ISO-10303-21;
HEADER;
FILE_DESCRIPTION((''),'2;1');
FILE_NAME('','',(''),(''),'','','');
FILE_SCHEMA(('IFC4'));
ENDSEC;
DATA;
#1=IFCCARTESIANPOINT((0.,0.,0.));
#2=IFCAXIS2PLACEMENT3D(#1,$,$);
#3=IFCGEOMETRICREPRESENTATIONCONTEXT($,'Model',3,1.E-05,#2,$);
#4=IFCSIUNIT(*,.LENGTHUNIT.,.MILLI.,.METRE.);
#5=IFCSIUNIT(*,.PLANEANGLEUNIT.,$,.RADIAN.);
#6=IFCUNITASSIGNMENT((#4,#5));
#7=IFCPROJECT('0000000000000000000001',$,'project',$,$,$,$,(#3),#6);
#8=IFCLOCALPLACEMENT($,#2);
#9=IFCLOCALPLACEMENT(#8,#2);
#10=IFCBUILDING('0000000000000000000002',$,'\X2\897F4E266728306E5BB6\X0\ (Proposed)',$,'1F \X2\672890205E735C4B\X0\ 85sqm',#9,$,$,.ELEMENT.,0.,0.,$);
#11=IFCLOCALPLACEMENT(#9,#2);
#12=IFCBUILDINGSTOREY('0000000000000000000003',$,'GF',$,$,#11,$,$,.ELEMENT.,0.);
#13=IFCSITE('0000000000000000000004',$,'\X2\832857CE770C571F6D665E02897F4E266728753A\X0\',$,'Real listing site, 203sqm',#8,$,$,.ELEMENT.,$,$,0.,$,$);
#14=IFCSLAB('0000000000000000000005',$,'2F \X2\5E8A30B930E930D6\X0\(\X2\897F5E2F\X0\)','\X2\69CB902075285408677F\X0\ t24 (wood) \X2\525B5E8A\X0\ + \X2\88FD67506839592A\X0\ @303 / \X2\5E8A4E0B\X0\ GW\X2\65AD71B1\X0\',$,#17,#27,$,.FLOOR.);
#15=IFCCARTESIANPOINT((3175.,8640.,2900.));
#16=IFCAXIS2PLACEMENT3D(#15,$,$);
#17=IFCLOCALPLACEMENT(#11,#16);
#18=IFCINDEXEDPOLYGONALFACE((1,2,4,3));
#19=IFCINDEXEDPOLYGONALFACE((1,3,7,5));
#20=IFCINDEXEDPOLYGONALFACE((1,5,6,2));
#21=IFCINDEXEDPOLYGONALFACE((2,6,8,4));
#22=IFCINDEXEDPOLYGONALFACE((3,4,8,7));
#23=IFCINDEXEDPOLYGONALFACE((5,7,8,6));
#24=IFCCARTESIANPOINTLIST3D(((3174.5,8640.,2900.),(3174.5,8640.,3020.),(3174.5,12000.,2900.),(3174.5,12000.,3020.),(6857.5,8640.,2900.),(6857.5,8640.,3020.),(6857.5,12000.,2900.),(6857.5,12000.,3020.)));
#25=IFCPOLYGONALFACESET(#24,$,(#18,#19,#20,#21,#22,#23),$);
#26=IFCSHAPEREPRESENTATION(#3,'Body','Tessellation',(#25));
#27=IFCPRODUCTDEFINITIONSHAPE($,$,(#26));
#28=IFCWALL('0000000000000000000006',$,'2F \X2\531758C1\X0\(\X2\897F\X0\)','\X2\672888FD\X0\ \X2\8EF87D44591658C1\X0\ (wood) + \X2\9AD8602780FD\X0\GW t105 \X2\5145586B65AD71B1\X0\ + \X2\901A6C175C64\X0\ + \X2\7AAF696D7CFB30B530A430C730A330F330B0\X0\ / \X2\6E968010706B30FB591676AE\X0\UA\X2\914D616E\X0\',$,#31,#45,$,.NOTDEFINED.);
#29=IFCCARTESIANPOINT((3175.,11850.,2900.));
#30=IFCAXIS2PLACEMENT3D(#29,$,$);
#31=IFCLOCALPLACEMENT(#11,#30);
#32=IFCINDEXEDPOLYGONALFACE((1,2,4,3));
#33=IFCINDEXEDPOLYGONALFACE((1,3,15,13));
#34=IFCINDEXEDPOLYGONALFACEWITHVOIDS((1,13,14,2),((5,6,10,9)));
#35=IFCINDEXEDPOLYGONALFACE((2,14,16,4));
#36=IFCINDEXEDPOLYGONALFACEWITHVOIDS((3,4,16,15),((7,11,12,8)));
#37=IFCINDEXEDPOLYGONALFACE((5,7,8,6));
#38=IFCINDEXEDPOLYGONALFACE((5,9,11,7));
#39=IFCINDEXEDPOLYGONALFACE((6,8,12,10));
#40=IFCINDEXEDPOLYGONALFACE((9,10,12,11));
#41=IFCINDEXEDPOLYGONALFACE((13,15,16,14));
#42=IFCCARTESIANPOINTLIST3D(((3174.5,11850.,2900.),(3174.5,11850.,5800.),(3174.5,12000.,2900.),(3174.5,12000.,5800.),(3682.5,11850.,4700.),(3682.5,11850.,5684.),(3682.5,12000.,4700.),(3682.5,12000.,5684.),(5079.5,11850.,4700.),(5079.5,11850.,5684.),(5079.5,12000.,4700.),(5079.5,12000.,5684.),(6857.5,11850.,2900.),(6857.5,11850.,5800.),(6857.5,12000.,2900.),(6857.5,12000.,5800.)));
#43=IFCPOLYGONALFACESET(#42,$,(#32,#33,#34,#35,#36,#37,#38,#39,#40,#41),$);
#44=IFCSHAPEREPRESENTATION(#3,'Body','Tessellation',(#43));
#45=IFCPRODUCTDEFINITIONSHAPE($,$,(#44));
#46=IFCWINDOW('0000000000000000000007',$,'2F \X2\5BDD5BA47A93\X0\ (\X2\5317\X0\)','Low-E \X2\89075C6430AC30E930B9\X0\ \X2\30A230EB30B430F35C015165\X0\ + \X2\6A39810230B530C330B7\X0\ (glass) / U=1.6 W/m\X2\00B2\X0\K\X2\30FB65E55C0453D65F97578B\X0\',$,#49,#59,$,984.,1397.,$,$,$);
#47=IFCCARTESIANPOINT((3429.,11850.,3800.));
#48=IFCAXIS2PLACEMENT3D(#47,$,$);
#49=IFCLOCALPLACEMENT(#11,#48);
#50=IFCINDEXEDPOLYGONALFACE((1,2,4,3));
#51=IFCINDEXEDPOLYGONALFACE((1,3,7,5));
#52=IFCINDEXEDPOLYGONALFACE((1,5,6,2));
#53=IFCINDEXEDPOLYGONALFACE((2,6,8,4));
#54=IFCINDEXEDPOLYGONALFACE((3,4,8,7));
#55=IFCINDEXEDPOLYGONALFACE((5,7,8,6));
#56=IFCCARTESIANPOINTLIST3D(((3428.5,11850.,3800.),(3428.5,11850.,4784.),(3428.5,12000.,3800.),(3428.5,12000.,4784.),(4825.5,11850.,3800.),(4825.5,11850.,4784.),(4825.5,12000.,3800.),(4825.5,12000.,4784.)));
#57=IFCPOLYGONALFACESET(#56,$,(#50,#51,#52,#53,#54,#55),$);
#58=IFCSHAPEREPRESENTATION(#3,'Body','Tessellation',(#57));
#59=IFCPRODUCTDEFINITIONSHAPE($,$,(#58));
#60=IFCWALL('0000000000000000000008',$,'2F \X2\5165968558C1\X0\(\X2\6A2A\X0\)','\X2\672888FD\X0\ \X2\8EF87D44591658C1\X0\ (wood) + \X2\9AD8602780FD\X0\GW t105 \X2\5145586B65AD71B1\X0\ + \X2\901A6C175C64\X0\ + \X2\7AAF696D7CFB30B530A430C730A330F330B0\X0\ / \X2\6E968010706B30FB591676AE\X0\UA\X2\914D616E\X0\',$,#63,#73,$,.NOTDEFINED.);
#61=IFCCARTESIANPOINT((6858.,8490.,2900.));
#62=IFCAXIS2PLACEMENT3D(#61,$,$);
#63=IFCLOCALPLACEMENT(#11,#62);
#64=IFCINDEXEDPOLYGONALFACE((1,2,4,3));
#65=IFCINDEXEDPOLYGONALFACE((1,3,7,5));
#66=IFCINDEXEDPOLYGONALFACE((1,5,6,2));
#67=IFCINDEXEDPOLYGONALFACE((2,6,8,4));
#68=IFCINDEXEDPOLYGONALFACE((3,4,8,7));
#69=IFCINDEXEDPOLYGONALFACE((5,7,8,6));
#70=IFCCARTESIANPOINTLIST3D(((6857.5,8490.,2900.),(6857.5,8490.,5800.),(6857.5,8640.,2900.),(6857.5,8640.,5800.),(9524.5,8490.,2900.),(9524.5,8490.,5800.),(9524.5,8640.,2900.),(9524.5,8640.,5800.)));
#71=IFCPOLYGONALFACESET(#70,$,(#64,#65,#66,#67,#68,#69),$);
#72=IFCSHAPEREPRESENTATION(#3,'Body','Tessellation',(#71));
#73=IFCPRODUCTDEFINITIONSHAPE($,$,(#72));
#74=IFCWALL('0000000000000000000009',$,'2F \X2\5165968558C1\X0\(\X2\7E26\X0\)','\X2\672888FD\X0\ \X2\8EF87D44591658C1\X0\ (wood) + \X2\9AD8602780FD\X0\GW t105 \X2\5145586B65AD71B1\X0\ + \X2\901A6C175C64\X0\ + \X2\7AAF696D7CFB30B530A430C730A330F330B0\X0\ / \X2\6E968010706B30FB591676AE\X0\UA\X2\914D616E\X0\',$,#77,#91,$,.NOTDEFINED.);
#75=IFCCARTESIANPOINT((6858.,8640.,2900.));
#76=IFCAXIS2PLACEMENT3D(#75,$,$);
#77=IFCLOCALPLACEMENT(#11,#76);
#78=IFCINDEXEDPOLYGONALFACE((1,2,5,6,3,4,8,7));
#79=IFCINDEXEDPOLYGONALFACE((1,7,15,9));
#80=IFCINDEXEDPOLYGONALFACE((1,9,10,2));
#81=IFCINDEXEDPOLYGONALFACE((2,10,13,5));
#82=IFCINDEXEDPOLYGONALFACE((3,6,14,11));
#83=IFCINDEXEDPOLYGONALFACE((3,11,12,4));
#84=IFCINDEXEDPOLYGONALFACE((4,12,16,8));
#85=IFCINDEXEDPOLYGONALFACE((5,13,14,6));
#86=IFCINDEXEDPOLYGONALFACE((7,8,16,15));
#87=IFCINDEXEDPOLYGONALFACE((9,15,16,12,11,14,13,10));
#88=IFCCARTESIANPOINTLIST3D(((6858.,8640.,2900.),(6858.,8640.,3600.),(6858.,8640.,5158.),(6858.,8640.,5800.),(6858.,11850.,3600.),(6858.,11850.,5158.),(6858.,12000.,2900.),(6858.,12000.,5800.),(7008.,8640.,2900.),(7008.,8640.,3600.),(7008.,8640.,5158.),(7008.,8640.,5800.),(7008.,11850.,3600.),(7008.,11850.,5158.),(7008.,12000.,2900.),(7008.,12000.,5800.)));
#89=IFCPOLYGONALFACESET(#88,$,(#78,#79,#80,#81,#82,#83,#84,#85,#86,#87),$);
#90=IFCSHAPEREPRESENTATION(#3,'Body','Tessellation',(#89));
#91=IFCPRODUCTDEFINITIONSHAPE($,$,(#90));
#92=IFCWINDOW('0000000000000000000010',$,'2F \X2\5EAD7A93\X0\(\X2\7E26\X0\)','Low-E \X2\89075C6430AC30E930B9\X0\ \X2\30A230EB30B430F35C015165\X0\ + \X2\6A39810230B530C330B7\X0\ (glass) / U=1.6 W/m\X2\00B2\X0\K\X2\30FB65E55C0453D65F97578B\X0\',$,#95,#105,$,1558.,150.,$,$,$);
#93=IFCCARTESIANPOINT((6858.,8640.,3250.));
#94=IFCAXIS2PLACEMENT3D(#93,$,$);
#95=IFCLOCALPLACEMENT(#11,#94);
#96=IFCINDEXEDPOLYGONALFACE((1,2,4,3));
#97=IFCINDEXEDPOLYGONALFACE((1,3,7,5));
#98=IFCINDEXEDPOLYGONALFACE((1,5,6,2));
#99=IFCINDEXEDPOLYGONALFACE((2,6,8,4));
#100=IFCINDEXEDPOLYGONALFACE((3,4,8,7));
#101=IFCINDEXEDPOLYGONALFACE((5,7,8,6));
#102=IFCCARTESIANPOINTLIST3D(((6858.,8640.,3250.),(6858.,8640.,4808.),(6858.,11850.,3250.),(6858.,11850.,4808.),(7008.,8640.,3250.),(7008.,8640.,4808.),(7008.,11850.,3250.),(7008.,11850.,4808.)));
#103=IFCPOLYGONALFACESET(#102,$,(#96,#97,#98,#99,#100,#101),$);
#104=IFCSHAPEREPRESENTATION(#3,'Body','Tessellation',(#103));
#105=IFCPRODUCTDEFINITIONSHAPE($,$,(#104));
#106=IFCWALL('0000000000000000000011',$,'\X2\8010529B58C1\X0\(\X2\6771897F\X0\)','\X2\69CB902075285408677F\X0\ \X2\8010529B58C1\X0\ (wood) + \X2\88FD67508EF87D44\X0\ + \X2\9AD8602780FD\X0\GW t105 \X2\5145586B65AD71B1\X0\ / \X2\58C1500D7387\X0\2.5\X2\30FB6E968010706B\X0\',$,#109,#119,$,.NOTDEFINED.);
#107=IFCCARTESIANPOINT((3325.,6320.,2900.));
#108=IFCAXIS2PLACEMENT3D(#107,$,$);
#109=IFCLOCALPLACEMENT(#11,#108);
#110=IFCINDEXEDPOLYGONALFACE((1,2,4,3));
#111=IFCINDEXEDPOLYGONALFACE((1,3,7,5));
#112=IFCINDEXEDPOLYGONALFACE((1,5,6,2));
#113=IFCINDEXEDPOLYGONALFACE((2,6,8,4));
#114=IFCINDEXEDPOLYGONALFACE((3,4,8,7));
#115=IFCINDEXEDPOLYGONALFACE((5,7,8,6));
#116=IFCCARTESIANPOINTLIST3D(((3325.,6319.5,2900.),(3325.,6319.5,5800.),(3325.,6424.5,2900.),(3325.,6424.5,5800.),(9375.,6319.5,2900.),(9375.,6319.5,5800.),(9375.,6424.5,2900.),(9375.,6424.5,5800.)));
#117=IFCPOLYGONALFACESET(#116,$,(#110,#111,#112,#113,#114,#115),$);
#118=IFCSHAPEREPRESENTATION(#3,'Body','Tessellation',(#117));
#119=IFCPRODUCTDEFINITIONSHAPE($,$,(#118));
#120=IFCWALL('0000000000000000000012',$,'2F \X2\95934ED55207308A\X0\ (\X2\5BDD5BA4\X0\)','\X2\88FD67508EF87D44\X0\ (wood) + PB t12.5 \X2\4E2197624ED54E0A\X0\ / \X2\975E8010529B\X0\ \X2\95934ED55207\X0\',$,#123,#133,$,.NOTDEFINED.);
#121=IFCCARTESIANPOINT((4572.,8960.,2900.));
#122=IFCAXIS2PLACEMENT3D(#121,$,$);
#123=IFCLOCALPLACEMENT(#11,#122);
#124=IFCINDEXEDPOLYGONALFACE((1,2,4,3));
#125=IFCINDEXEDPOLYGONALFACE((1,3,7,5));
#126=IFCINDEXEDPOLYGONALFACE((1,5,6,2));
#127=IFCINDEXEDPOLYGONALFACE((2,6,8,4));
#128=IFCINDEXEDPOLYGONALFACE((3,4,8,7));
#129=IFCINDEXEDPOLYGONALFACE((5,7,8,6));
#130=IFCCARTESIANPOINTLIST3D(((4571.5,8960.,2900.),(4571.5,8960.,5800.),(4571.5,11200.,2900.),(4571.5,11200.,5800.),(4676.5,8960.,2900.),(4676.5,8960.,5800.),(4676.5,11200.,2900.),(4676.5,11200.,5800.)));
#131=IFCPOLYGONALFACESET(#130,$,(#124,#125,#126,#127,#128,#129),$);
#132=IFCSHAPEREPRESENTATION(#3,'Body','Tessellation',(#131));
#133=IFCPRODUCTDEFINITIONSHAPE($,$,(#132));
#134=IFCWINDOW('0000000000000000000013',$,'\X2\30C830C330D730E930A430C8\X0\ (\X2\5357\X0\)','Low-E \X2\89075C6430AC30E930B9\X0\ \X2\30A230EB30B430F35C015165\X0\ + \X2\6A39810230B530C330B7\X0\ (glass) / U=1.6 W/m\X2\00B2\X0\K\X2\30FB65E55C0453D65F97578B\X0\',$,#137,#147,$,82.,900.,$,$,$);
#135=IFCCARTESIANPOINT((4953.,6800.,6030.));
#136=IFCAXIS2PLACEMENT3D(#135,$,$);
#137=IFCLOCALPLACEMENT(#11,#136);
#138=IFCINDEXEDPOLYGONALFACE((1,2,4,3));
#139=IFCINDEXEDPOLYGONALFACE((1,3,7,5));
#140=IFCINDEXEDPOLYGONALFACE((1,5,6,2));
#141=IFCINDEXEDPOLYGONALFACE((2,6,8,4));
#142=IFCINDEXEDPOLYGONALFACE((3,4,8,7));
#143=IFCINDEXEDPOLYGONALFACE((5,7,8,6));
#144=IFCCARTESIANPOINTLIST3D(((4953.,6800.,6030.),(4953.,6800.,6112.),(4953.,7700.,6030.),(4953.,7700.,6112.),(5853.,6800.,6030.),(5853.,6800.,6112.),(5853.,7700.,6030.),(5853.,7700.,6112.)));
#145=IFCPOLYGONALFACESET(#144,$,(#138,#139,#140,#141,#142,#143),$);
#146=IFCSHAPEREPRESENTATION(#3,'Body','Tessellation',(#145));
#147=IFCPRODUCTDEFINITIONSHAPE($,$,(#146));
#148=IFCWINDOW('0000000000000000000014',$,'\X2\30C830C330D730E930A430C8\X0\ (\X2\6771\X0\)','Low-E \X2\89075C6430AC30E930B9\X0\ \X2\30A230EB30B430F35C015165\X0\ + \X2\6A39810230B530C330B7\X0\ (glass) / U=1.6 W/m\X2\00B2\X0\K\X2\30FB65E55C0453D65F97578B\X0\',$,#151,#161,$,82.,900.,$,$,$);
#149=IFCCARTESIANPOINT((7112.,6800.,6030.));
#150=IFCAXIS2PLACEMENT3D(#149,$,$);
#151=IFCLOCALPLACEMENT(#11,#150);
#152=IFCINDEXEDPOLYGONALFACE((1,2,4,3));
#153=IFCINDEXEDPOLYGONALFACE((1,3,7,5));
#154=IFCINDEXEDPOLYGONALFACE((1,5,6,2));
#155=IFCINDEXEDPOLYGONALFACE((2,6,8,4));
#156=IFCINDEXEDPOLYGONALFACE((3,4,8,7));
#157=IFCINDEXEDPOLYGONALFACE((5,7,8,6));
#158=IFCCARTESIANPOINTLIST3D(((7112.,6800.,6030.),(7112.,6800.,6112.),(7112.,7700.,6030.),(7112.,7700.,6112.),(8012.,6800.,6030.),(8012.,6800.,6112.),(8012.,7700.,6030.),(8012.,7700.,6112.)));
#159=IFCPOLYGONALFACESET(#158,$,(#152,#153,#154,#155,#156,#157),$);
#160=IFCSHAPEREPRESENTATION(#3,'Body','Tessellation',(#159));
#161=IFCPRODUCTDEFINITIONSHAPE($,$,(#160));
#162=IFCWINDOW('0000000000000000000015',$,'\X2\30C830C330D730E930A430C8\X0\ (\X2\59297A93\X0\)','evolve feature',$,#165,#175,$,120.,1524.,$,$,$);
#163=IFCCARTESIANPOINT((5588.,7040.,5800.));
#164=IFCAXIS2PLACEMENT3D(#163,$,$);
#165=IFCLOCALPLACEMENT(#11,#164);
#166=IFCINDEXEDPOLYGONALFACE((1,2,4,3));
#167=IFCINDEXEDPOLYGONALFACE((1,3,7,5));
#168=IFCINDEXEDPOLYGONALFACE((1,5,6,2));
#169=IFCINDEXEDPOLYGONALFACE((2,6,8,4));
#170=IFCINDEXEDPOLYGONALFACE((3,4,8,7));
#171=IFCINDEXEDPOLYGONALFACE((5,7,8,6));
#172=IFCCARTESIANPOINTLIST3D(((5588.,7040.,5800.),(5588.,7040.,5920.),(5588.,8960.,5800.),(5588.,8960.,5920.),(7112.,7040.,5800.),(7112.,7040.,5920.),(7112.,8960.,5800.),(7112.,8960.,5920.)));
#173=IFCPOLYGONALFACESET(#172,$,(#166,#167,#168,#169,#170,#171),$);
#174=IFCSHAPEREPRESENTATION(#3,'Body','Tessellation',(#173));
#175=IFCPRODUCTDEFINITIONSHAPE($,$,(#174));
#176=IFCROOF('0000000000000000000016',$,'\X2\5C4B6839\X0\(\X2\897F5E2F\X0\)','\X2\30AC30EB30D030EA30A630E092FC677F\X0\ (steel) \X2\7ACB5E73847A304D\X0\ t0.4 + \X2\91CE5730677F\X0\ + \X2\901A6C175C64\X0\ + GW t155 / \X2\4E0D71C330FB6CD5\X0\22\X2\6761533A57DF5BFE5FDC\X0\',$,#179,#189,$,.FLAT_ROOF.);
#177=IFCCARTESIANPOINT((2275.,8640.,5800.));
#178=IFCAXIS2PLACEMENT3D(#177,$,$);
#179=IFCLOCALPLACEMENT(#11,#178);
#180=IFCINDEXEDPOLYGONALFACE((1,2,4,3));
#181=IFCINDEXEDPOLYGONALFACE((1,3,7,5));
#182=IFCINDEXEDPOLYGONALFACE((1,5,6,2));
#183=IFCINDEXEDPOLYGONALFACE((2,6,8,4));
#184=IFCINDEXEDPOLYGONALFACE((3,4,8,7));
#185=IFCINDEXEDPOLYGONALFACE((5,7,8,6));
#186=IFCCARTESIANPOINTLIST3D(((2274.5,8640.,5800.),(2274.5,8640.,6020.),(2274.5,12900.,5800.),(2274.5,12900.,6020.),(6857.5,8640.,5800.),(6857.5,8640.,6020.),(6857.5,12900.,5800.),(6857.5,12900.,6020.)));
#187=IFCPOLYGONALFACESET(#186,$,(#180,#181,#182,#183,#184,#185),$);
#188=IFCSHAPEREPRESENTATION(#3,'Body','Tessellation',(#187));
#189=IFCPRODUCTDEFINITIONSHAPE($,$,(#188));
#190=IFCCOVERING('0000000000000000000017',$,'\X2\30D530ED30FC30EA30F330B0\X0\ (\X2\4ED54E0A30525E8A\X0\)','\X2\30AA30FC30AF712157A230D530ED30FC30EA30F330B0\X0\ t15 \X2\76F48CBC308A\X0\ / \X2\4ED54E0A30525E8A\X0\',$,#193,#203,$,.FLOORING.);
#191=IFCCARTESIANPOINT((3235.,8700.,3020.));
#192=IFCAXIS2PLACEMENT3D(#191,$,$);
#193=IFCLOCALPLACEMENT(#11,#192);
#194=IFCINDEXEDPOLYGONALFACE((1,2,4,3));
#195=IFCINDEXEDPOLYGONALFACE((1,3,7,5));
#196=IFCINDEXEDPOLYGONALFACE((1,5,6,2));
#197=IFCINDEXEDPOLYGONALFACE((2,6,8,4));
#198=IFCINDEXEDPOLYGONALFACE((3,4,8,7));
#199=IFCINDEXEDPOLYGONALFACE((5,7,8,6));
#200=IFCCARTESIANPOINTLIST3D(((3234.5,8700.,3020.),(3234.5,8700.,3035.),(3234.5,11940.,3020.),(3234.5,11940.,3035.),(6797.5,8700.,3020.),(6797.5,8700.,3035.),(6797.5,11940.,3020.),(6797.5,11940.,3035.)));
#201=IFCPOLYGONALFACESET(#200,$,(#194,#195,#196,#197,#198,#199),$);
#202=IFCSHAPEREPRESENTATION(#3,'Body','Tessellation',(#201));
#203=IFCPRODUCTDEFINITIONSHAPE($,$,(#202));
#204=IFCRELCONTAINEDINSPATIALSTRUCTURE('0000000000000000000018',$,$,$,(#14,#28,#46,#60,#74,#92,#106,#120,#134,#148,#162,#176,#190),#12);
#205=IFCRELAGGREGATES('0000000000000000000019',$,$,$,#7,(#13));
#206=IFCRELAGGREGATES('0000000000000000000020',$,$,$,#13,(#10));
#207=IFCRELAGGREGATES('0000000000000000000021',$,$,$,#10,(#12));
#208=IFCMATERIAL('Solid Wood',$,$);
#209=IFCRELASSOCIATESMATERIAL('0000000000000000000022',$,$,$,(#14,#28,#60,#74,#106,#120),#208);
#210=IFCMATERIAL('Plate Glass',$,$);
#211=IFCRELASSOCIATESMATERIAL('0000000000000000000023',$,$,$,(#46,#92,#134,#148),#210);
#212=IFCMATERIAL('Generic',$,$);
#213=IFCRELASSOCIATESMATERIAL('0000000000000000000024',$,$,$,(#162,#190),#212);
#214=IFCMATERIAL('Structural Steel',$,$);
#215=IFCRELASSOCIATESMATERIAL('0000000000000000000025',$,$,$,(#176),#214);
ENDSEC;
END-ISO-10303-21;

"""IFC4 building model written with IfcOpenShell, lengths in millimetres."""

from ifc_helpers import new_model, si_unit, frame, frame_2d, origin, place, context, project, spatial, rectangle, extrude, material, element, fill, save


model = new_model("IFC4")

# Units and contexts
model_context = context("Model", 3, precision=1e-05, world=origin())
ifc_project = project(units=[si_unit("LENGTHUNIT", "METRE", prefix="MILLI"), si_unit("PLANEANGLEUNIT", "RADIAN")], contexts=[model_context])

# Site, building, storey
site_placement = place(None, origin())
site = spatial("IfcSite", under=ifc_project, at=site_placement, Name="茨城県土浦市西並木町", ObjectType="Real listing site, 203sqm", CompositionType="ELEMENT", RefElevation=0.0)
building_placement = place(site_placement, origin())
building = spatial("IfcBuilding", under=site, at=building_placement, Name="西並木の家 (Proposed)", ObjectType="1F 木造平屋 85sqm", CompositionType="ELEMENT", ElevationOfRefHeight=0.0, ElevationOfTerrain=0.0)
storey_placement = place(building_placement, origin())
storey = spatial("IfcBuildingStorey", under=building, at=storey_placement, Name="GF", CompositionType="ELEMENT", Elevation=0.0)

# Slab
ifc_material_1 = material(Name="Solid Wood")
slab_placement = place(storey_placement, frame((3175.0, 8640.0, 2900.0)))
element("IfcSlab", 1, at=slab_placement, inside=storey, material=ifc_material_1, Name="2F 床スラブ(西帯)", Description="構造用合板 t24 (wood) 剛床 + 製材根太 @303 / 床下 GW断熱", PredefinedType="FLOOR", context=model_context, shape_type="SweptSolid", body=[
    extrude(rectangle(XDim=3683.0, YDim=3360.0, at=frame_2d((1841.0, 1680.0))), frame((3175.0, 8640.0, 2900.0)), (0.0, 0.0, 1.0), 120.0),
])

# Wall, opening, window
wall_1_placement = place(storey_placement, frame((3175.0, 11850.0, 2900.0)))
wall_1 = element("IfcWall", 2, at=wall_1_placement, inside=storey, material=ifc_material_1, Name="2F 北壁(西)", Description="木製 軸組外壁 (wood) + 高性能GW t105 充填断熱 + 通気層 + 窯業系サイディング / 準耐火・外皮UA配慮", PredefinedType="NOTDEFINED", context=model_context, shape_type="SweptSolid", body=[
    extrude(rectangle(XDim=3683.0, YDim=150.0, at=frame_2d((1841.0, 75.0))), frame((3175.0, 11850.0, 2900.0)), (0.0, 0.0, 1.0), 2900.0),
])
opening_1_placement = place(storey_placement, frame((3429.0, 11850.0, 3800.0)))
opening_1 = element("IfcOpeningElement", 3, at=opening_1_placement, cuts=wall_1, PredefinedType="NOTDEFINED", context=model_context, shape_type="SweptSolid", body=[
    extrude(rectangle(XDim=1397.0, YDim=150.0, at=frame_2d((698.0, 75.0))), frame((3429.0, 11850.0, 3800.0)), (0.0, 0.0, 1.0), 984.0),
])
ifc_material_2 = material(Name="Plate Glass")
window_1_placement = place(storey_placement, frame((3429.0, 11850.0, 3800.0)))
window_1 = element("IfcWindow", 4, at=window_1_placement, inside=storey, material=ifc_material_2, Name="2F 寝室窓 (北)", Description="Low-E 複層ガラス アルゴン封入 + 樹脂サッシ (glass) / U=1.6 W/m²K・日射取得型", OverallHeight=984.0, OverallWidth=1397.0, context=model_context, shape_type="SweptSolid", body=[
    extrude(rectangle(XDim=1397.0, YDim=150.0, at=frame_2d((698.0, 75.0))), frame((3429.0, 11850.0, 3800.0)), (0.0, 0.0, 1.0), 984.0),
])
fill(opening_1, window_1)

# Wall
wall_2_placement = place(storey_placement, frame((6858.0, 8490.0, 2900.0)))
element("IfcWall", 5, at=wall_2_placement, inside=storey, material=ifc_material_1, Name="2F 入隅壁(横)", Description="木製 軸組外壁 (wood) + 高性能GW t105 充填断熱 + 通気層 + 窯業系サイディング / 準耐火・外皮UA配慮", PredefinedType="NOTDEFINED", context=model_context, shape_type="SweptSolid", body=[
    extrude(rectangle(XDim=2667.0, YDim=150.0, at=frame_2d((1333.0, 75.0))), frame((6858.0, 8490.0, 2900.0)), (0.0, 0.0, 1.0), 2900.0),
])

# Wall, opening, window
wall_3_placement = place(storey_placement, frame((6858.0, 8640.0, 2900.0)))
wall_3 = element("IfcWall", 6, at=wall_3_placement, inside=storey, material=ifc_material_1, Name="2F 入隅壁(縦)", Description="木製 軸組外壁 (wood) + 高性能GW t105 充填断熱 + 通気層 + 窯業系サイディング / 準耐火・外皮UA配慮", PredefinedType="NOTDEFINED", context=model_context, shape_type="SweptSolid", body=[
    extrude(rectangle(XDim=150.0, YDim=3360.0, at=frame_2d((75.0, 1680.0))), frame((6858.0, 8640.0, 2900.0)), (0.0, 0.0, 1.0), 2900.0),
])
opening_2_placement = place(storey_placement, frame((6858.0, 8640.0, 3250.0)))
opening_2 = element("IfcOpeningElement", 7, at=opening_2_placement, cuts=wall_3, PredefinedType="NOTDEFINED", context=model_context, shape_type="SweptSolid", body=[
    extrude(rectangle(XDim=150.0, YDim=3210.0, at=frame_2d((75.0, 1605.0))), frame((6858.0, 8640.0, 3250.0)), (0.0, 0.0, 1.0), 1558.0),
])
window_2_placement = place(storey_placement, frame((6858.0, 8640.0, 3250.0)))
window_2 = element("IfcWindow", 8, at=window_2_placement, inside=storey, material=ifc_material_2, Name="2F 庭窓(縦)", Description="Low-E 複層ガラス アルゴン封入 + 樹脂サッシ (glass) / U=1.6 W/m²K・日射取得型", OverallHeight=1558.0, OverallWidth=150.0, context=model_context, shape_type="SweptSolid", body=[
    extrude(rectangle(XDim=150.0, YDim=3210.0, at=frame_2d((75.0, 1605.0))), frame((6858.0, 8640.0, 3250.0)), (0.0, 0.0, 1.0), 1558.0),
])
fill(opening_2, window_2)

# Walls
wall_4_placement = place(storey_placement, frame((3325.0, 6320.0, 2900.0)))
element("IfcWall", 9, at=wall_4_placement, inside=storey, material=ifc_material_1, Name="耐力壁(東西)", Description="構造用合板 耐力壁 (wood) + 製材軸組 + 高性能GW t105 充填断熱 / 壁倍率2.5・準耐火", PredefinedType="NOTDEFINED", context=model_context, shape_type="SweptSolid", body=[
    extrude(rectangle(XDim=6050.0, YDim=105.0, at=frame_2d((3025.0, 52.0))), frame((3325.0, 6320.0, 2900.0)), (0.0, 0.0, 1.0), 2900.0),
])
wall_5_placement = place(storey_placement, frame((4572.0, 8960.0, 2900.0)))
element("IfcWall", 10, at=wall_5_placement, inside=storey, material=ifc_material_1, Name="2F 間仕切り (寝室)", Description="製材軸組 (wood) + PB t12.5 両面仕上 / 非耐力 間仕切", PredefinedType="NOTDEFINED", context=model_context, shape_type="SweptSolid", body=[
    extrude(rectangle(XDim=105.0, YDim=2240.0, at=frame_2d((52.0, 1120.0))), frame((4572.0, 8960.0, 2900.0)), (0.0, 0.0, 1.0), 2900.0),
])

# Windows
window_3_placement = place(storey_placement, frame((4953.0, 6800.0, 6030.0)))
element("IfcWindow", 11, at=window_3_placement, inside=storey, material=ifc_material_2, Name="トップライト (南)", Description="Low-E 複層ガラス アルゴン封入 + 樹脂サッシ (glass) / U=1.6 W/m²K・日射取得型", OverallHeight=82.0, OverallWidth=900.0, context=model_context, shape_type="SweptSolid", body=[
    extrude(rectangle(XDim=900.0, YDim=900.0, at=frame_2d((450.0, 450.0))), frame((4953.0, 6800.0, 6030.0)), (0.0, 0.0, 1.0), 82.0),
])
window_4_placement = place(storey_placement, frame((7112.0, 6800.0, 6030.0)))
element("IfcWindow", 12, at=window_4_placement, inside=storey, material=ifc_material_2, Name="トップライト (東)", Description="Low-E 複層ガラス アルゴン封入 + 樹脂サッシ (glass) / U=1.6 W/m²K・日射取得型", OverallHeight=82.0, OverallWidth=900.0, context=model_context, shape_type="SweptSolid", body=[
    extrude(rectangle(XDim=900.0, YDim=900.0, at=frame_2d((450.0, 450.0))), frame((7112.0, 6800.0, 6030.0)), (0.0, 0.0, 1.0), 82.0),
])
ifc_material_3 = material(Name="Generic")
window_5_placement = place(storey_placement, frame((5588.0, 7040.0, 5800.0)))
element("IfcWindow", 13, at=window_5_placement, inside=storey, material=ifc_material_3, Name="トップライト (天窓)", Description="evolve feature", OverallHeight=120.0, OverallWidth=1524.0, context=model_context, shape_type="SweptSolid", body=[
    extrude(rectangle(XDim=1524.0, YDim=1920.0, at=frame_2d((762.0, 960.0))), frame((5588.0, 7040.0, 5800.0)), (0.0, 0.0, 1.0), 120.0),
])

# Roof
ifc_material_4 = material(Name="Structural Steel")
for number, where, name in (
    (14, (2275.0, 8640.0, 5800.0), "屋根(西帯)"),
):
    element("IfcRoof", number, at=place(storey_placement, frame(where)), inside=storey, material=ifc_material_4, Name=name, Description="ガルバリウム鋼板 (steel) 立平葺き t0.4 + 野地板 + 通気層 + GW t155 / 不燃・法22条区域対応", PredefinedType="FLAT_ROOF", context=model_context, shape_type="SweptSolid", body=[
        extrude(rectangle(XDim=4583.0, YDim=4260.0, at=frame_2d((2291.0, 2130.0))), frame((2275.0, 8640.0, 5800.0)), (0.0, 0.0, 1.0), 220.0),
    ])

# Covering
covering_placement = place(storey_placement, frame((3235.0, 8700.0, 3020.0)))
element("IfcCovering", 15, at=covering_placement, inside=storey, material=ifc_material_3, Name="フローリング (仕上げ床)", Description="オーク無垢フローリング t15 直貼り / 仕上げ床", PredefinedType="FLOORING", context=model_context, shape_type="SweptSolid", body=[
    extrude(rectangle(XDim=3563.0, YDim=3240.0, at=frame_2d((1781.0, 1620.0))), frame((3235.0, 8700.0, 3020.0)), (0.0, 0.0, 1.0), 15.0),
])

save(model, "model.ifc")
